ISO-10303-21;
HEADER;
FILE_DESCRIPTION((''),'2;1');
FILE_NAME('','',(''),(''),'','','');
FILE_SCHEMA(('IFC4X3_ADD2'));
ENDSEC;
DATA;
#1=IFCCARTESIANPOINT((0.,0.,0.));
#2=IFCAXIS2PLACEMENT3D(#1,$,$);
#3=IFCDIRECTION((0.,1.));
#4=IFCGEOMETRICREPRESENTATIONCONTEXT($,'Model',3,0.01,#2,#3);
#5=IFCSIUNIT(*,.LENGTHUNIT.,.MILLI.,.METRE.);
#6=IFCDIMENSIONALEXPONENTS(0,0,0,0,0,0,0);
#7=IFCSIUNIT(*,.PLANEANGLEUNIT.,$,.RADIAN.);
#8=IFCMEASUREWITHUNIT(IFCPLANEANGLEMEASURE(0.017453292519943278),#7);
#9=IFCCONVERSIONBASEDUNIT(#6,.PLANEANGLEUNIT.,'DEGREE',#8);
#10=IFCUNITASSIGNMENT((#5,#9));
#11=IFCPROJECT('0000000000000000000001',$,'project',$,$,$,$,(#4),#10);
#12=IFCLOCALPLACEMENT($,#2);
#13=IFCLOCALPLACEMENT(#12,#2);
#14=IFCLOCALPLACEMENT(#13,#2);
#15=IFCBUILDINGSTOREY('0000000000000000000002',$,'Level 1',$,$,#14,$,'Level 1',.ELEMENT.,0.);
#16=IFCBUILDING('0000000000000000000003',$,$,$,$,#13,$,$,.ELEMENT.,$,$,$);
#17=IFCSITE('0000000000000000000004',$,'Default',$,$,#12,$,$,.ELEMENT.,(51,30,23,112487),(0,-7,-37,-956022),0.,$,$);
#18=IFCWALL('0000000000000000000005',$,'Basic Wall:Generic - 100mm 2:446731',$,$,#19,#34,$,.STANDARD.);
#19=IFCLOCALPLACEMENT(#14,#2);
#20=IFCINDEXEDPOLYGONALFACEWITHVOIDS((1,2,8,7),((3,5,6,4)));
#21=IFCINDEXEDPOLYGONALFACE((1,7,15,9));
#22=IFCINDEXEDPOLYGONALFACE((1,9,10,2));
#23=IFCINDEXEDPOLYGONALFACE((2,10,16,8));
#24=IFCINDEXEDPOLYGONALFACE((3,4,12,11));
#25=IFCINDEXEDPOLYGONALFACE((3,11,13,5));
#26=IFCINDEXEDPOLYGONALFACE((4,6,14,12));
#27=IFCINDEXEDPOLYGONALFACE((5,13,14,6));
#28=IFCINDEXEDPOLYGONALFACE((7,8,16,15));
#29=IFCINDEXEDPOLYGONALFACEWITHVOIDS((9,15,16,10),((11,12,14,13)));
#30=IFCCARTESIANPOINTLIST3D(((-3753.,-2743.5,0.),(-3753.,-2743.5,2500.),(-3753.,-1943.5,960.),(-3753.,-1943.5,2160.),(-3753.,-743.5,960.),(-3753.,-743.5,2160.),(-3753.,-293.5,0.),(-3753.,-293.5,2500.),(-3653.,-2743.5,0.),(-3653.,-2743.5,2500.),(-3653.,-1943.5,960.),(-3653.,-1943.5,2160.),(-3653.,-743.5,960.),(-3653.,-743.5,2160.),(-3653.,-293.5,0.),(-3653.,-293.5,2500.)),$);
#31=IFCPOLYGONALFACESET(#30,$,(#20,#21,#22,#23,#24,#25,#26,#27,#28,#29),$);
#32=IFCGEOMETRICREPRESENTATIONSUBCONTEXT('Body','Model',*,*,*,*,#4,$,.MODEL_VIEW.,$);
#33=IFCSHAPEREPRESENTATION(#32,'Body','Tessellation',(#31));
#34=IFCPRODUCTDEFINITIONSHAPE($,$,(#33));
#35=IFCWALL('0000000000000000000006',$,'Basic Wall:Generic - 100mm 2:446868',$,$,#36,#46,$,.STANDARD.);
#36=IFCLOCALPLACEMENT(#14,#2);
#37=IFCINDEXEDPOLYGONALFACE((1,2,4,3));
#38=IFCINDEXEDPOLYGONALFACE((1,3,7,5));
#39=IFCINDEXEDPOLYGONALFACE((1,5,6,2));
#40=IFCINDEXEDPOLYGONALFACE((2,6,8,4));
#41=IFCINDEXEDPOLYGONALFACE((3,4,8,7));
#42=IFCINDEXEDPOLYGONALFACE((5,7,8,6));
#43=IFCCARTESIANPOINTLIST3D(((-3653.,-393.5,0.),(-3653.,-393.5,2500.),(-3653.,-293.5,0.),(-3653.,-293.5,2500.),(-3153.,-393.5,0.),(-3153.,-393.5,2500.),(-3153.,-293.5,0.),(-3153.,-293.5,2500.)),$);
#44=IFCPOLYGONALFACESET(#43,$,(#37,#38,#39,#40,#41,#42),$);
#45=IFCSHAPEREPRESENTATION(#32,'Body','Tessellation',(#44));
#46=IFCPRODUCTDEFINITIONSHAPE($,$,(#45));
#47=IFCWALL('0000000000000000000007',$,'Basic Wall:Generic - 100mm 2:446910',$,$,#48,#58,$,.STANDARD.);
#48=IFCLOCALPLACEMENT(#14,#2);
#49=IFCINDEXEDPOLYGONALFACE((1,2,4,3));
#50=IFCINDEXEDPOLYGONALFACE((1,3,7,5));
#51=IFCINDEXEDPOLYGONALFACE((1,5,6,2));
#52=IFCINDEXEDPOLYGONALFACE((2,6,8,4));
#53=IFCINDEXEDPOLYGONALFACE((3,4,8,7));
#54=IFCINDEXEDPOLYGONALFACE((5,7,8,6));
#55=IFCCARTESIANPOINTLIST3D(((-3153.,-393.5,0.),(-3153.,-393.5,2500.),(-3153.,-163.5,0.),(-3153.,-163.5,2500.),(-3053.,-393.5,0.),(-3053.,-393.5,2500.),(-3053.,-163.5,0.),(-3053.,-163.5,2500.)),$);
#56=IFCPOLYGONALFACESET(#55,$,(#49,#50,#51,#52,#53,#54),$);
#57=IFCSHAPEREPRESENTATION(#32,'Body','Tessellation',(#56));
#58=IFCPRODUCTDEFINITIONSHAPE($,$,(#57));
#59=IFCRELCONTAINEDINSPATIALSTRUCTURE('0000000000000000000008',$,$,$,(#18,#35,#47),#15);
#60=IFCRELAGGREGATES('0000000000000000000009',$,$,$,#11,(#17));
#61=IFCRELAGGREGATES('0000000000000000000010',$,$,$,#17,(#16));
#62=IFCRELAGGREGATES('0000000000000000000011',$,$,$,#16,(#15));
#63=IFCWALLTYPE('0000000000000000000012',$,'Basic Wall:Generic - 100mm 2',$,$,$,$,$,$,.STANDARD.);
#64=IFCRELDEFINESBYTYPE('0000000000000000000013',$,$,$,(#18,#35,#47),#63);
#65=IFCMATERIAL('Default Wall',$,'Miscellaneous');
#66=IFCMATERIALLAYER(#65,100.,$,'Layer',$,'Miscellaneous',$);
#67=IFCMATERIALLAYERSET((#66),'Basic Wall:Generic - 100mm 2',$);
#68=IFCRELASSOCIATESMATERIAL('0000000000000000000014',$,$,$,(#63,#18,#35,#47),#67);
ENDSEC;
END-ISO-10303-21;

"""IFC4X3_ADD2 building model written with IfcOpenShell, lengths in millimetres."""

from ifc_helpers import new_model, entity, si_unit, converted_unit, direction, frame, frame_2d, origin, place, context, subcontext, project, spatial, rectangle, extrude, material, layer, layer_set, type_object, element, save


model = new_model("IFC4X3_ADD2")

# Units and contexts
model_context = context("Model", 3, precision=0.01, world=origin(), true_north=direction((0.0, 1.0)))
body_context = subcontext(model_context, "Body", "Model", "MODEL_VIEW")
ifc_project = project(units=[si_unit("LENGTHUNIT", "METRE", prefix="MILLI"), converted_unit("PLANEANGLEUNIT", "DEGREE", entity("IfcPlaneAngleMeasure", 0.017453292519943278), si_unit("PLANEANGLEUNIT", "RADIAN"), dimensions=[0, 0, 0, 0, 0, 0, 0])], contexts=[model_context])

# Site, building, storey
site_placement = place(None, origin())
site = spatial("IfcSite", under=ifc_project, at=site_placement, Name="Default", CompositionType="ELEMENT", RefLatitude=(51, 30, 23, 112487), RefLongitude=(0, -7, -37, -956022), RefElevation=0.0)
building_placement = place(site_placement, origin())
building = spatial("IfcBuilding", under=site, at=building_placement, CompositionType="ELEMENT")
storey_placement = place(building_placement, origin())
storey = spatial("IfcBuildingStorey", under=building, at=storey_placement, Name="Level 1", LongName="Level 1", CompositionType="ELEMENT", Elevation=0.0)

# Shared definitions
ifc_material = material(Name="Default Wall", Category="Miscellaneous")
ifc_layer = layer(ifc_material, 100.0, Name="Layer", Category="Miscellaneous")
ifc_layer_set = layer_set([ifc_layer], Name="Basic Wall:Generic - 100mm 2")
wall_type = type_object("IfcWallType", Name="Basic Wall:Generic - 100mm 2", PredefinedType="STANDARD", material=ifc_layer_set)

# Wall, opening
wall_1_placement = place(storey_placement, frame((-3703.0, -293.5, 0.0), z_axis=(0.0, 0.0, 1.0), x_axis=(0.0, -1.0, 0.0)))
wall_1 = element("IfcWall", 1, at=wall_1_placement, inside=storey, type_object=wall_type, material=ifc_layer_set, Name="Basic Wall:Generic - 100mm 2:446731", PredefinedType="STANDARD", context=body_context, shape_type="SweptSolid", body=[
    extrude(rectangle(XDim=2450.0, YDim=100.0, at=frame_2d((1225.0, 0.0), x_axis=(-1.0, 0.0))), origin(), (0.0, 0.0, 1.0), 2500.0),
])
opening_1_placement = place(wall_1_placement, frame((450.0, -50.0, 960.0)))
element("IfcOpeningElement", 2, at=opening_1_placement, cuts=wall_1, PredefinedType="OPENING", context=body_context, shape_type="SweptSolid", body=[
    extrude(rectangle(XDim=1200.0, YDim=1200.0, at=frame_2d((600.0, 600.0), x_axis=(-1.0, 0.0))), frame((0.0, 0.0, 0.0), z_axis=(0.0, 1.0, 0.0), x_axis=(0.0, 0.0, 1.0)), (0.0, 0.0, 1.0), 100.0),
])

# Walls
wall_2_placement = place(storey_placement, frame((-3653.0, -343.5, 0.0)))
element("IfcWall", 3, at=wall_2_placement, inside=storey, type_object=wall_type, material=ifc_layer_set, Name="Basic Wall:Generic - 100mm 2:446868", PredefinedType="STANDARD", context=body_context, shape_type="SweptSolid", body=[
    extrude(rectangle(XDim=500.0, YDim=100.0, at=frame_2d((250.0, 0.0), x_axis=(-1.0, 0.0))), origin(), (0.0, 0.0, 1.0), 2500.0),
])
wall_3_placement = place(storey_placement, frame((-3103.0, -393.5, 0.0), z_axis=(0.0, 0.0, 1.0), x_axis=(0.0, 1.0, 0.0)))
element("IfcWall", 4, at=wall_3_placement, inside=storey, type_object=wall_type, material=ifc_layer_set, Name="Basic Wall:Generic - 100mm 2:446910", PredefinedType="STANDARD", context=body_context, shape_type="SweptSolid", body=[
    extrude(rectangle(XDim=230.0, YDim=100.0, at=frame_2d((115.0, 0.0), x_axis=(-1.0, 0.0))), origin(), (0.0, 0.0, 1.0), 2500.0),
])

save(model, "model.ifc")
